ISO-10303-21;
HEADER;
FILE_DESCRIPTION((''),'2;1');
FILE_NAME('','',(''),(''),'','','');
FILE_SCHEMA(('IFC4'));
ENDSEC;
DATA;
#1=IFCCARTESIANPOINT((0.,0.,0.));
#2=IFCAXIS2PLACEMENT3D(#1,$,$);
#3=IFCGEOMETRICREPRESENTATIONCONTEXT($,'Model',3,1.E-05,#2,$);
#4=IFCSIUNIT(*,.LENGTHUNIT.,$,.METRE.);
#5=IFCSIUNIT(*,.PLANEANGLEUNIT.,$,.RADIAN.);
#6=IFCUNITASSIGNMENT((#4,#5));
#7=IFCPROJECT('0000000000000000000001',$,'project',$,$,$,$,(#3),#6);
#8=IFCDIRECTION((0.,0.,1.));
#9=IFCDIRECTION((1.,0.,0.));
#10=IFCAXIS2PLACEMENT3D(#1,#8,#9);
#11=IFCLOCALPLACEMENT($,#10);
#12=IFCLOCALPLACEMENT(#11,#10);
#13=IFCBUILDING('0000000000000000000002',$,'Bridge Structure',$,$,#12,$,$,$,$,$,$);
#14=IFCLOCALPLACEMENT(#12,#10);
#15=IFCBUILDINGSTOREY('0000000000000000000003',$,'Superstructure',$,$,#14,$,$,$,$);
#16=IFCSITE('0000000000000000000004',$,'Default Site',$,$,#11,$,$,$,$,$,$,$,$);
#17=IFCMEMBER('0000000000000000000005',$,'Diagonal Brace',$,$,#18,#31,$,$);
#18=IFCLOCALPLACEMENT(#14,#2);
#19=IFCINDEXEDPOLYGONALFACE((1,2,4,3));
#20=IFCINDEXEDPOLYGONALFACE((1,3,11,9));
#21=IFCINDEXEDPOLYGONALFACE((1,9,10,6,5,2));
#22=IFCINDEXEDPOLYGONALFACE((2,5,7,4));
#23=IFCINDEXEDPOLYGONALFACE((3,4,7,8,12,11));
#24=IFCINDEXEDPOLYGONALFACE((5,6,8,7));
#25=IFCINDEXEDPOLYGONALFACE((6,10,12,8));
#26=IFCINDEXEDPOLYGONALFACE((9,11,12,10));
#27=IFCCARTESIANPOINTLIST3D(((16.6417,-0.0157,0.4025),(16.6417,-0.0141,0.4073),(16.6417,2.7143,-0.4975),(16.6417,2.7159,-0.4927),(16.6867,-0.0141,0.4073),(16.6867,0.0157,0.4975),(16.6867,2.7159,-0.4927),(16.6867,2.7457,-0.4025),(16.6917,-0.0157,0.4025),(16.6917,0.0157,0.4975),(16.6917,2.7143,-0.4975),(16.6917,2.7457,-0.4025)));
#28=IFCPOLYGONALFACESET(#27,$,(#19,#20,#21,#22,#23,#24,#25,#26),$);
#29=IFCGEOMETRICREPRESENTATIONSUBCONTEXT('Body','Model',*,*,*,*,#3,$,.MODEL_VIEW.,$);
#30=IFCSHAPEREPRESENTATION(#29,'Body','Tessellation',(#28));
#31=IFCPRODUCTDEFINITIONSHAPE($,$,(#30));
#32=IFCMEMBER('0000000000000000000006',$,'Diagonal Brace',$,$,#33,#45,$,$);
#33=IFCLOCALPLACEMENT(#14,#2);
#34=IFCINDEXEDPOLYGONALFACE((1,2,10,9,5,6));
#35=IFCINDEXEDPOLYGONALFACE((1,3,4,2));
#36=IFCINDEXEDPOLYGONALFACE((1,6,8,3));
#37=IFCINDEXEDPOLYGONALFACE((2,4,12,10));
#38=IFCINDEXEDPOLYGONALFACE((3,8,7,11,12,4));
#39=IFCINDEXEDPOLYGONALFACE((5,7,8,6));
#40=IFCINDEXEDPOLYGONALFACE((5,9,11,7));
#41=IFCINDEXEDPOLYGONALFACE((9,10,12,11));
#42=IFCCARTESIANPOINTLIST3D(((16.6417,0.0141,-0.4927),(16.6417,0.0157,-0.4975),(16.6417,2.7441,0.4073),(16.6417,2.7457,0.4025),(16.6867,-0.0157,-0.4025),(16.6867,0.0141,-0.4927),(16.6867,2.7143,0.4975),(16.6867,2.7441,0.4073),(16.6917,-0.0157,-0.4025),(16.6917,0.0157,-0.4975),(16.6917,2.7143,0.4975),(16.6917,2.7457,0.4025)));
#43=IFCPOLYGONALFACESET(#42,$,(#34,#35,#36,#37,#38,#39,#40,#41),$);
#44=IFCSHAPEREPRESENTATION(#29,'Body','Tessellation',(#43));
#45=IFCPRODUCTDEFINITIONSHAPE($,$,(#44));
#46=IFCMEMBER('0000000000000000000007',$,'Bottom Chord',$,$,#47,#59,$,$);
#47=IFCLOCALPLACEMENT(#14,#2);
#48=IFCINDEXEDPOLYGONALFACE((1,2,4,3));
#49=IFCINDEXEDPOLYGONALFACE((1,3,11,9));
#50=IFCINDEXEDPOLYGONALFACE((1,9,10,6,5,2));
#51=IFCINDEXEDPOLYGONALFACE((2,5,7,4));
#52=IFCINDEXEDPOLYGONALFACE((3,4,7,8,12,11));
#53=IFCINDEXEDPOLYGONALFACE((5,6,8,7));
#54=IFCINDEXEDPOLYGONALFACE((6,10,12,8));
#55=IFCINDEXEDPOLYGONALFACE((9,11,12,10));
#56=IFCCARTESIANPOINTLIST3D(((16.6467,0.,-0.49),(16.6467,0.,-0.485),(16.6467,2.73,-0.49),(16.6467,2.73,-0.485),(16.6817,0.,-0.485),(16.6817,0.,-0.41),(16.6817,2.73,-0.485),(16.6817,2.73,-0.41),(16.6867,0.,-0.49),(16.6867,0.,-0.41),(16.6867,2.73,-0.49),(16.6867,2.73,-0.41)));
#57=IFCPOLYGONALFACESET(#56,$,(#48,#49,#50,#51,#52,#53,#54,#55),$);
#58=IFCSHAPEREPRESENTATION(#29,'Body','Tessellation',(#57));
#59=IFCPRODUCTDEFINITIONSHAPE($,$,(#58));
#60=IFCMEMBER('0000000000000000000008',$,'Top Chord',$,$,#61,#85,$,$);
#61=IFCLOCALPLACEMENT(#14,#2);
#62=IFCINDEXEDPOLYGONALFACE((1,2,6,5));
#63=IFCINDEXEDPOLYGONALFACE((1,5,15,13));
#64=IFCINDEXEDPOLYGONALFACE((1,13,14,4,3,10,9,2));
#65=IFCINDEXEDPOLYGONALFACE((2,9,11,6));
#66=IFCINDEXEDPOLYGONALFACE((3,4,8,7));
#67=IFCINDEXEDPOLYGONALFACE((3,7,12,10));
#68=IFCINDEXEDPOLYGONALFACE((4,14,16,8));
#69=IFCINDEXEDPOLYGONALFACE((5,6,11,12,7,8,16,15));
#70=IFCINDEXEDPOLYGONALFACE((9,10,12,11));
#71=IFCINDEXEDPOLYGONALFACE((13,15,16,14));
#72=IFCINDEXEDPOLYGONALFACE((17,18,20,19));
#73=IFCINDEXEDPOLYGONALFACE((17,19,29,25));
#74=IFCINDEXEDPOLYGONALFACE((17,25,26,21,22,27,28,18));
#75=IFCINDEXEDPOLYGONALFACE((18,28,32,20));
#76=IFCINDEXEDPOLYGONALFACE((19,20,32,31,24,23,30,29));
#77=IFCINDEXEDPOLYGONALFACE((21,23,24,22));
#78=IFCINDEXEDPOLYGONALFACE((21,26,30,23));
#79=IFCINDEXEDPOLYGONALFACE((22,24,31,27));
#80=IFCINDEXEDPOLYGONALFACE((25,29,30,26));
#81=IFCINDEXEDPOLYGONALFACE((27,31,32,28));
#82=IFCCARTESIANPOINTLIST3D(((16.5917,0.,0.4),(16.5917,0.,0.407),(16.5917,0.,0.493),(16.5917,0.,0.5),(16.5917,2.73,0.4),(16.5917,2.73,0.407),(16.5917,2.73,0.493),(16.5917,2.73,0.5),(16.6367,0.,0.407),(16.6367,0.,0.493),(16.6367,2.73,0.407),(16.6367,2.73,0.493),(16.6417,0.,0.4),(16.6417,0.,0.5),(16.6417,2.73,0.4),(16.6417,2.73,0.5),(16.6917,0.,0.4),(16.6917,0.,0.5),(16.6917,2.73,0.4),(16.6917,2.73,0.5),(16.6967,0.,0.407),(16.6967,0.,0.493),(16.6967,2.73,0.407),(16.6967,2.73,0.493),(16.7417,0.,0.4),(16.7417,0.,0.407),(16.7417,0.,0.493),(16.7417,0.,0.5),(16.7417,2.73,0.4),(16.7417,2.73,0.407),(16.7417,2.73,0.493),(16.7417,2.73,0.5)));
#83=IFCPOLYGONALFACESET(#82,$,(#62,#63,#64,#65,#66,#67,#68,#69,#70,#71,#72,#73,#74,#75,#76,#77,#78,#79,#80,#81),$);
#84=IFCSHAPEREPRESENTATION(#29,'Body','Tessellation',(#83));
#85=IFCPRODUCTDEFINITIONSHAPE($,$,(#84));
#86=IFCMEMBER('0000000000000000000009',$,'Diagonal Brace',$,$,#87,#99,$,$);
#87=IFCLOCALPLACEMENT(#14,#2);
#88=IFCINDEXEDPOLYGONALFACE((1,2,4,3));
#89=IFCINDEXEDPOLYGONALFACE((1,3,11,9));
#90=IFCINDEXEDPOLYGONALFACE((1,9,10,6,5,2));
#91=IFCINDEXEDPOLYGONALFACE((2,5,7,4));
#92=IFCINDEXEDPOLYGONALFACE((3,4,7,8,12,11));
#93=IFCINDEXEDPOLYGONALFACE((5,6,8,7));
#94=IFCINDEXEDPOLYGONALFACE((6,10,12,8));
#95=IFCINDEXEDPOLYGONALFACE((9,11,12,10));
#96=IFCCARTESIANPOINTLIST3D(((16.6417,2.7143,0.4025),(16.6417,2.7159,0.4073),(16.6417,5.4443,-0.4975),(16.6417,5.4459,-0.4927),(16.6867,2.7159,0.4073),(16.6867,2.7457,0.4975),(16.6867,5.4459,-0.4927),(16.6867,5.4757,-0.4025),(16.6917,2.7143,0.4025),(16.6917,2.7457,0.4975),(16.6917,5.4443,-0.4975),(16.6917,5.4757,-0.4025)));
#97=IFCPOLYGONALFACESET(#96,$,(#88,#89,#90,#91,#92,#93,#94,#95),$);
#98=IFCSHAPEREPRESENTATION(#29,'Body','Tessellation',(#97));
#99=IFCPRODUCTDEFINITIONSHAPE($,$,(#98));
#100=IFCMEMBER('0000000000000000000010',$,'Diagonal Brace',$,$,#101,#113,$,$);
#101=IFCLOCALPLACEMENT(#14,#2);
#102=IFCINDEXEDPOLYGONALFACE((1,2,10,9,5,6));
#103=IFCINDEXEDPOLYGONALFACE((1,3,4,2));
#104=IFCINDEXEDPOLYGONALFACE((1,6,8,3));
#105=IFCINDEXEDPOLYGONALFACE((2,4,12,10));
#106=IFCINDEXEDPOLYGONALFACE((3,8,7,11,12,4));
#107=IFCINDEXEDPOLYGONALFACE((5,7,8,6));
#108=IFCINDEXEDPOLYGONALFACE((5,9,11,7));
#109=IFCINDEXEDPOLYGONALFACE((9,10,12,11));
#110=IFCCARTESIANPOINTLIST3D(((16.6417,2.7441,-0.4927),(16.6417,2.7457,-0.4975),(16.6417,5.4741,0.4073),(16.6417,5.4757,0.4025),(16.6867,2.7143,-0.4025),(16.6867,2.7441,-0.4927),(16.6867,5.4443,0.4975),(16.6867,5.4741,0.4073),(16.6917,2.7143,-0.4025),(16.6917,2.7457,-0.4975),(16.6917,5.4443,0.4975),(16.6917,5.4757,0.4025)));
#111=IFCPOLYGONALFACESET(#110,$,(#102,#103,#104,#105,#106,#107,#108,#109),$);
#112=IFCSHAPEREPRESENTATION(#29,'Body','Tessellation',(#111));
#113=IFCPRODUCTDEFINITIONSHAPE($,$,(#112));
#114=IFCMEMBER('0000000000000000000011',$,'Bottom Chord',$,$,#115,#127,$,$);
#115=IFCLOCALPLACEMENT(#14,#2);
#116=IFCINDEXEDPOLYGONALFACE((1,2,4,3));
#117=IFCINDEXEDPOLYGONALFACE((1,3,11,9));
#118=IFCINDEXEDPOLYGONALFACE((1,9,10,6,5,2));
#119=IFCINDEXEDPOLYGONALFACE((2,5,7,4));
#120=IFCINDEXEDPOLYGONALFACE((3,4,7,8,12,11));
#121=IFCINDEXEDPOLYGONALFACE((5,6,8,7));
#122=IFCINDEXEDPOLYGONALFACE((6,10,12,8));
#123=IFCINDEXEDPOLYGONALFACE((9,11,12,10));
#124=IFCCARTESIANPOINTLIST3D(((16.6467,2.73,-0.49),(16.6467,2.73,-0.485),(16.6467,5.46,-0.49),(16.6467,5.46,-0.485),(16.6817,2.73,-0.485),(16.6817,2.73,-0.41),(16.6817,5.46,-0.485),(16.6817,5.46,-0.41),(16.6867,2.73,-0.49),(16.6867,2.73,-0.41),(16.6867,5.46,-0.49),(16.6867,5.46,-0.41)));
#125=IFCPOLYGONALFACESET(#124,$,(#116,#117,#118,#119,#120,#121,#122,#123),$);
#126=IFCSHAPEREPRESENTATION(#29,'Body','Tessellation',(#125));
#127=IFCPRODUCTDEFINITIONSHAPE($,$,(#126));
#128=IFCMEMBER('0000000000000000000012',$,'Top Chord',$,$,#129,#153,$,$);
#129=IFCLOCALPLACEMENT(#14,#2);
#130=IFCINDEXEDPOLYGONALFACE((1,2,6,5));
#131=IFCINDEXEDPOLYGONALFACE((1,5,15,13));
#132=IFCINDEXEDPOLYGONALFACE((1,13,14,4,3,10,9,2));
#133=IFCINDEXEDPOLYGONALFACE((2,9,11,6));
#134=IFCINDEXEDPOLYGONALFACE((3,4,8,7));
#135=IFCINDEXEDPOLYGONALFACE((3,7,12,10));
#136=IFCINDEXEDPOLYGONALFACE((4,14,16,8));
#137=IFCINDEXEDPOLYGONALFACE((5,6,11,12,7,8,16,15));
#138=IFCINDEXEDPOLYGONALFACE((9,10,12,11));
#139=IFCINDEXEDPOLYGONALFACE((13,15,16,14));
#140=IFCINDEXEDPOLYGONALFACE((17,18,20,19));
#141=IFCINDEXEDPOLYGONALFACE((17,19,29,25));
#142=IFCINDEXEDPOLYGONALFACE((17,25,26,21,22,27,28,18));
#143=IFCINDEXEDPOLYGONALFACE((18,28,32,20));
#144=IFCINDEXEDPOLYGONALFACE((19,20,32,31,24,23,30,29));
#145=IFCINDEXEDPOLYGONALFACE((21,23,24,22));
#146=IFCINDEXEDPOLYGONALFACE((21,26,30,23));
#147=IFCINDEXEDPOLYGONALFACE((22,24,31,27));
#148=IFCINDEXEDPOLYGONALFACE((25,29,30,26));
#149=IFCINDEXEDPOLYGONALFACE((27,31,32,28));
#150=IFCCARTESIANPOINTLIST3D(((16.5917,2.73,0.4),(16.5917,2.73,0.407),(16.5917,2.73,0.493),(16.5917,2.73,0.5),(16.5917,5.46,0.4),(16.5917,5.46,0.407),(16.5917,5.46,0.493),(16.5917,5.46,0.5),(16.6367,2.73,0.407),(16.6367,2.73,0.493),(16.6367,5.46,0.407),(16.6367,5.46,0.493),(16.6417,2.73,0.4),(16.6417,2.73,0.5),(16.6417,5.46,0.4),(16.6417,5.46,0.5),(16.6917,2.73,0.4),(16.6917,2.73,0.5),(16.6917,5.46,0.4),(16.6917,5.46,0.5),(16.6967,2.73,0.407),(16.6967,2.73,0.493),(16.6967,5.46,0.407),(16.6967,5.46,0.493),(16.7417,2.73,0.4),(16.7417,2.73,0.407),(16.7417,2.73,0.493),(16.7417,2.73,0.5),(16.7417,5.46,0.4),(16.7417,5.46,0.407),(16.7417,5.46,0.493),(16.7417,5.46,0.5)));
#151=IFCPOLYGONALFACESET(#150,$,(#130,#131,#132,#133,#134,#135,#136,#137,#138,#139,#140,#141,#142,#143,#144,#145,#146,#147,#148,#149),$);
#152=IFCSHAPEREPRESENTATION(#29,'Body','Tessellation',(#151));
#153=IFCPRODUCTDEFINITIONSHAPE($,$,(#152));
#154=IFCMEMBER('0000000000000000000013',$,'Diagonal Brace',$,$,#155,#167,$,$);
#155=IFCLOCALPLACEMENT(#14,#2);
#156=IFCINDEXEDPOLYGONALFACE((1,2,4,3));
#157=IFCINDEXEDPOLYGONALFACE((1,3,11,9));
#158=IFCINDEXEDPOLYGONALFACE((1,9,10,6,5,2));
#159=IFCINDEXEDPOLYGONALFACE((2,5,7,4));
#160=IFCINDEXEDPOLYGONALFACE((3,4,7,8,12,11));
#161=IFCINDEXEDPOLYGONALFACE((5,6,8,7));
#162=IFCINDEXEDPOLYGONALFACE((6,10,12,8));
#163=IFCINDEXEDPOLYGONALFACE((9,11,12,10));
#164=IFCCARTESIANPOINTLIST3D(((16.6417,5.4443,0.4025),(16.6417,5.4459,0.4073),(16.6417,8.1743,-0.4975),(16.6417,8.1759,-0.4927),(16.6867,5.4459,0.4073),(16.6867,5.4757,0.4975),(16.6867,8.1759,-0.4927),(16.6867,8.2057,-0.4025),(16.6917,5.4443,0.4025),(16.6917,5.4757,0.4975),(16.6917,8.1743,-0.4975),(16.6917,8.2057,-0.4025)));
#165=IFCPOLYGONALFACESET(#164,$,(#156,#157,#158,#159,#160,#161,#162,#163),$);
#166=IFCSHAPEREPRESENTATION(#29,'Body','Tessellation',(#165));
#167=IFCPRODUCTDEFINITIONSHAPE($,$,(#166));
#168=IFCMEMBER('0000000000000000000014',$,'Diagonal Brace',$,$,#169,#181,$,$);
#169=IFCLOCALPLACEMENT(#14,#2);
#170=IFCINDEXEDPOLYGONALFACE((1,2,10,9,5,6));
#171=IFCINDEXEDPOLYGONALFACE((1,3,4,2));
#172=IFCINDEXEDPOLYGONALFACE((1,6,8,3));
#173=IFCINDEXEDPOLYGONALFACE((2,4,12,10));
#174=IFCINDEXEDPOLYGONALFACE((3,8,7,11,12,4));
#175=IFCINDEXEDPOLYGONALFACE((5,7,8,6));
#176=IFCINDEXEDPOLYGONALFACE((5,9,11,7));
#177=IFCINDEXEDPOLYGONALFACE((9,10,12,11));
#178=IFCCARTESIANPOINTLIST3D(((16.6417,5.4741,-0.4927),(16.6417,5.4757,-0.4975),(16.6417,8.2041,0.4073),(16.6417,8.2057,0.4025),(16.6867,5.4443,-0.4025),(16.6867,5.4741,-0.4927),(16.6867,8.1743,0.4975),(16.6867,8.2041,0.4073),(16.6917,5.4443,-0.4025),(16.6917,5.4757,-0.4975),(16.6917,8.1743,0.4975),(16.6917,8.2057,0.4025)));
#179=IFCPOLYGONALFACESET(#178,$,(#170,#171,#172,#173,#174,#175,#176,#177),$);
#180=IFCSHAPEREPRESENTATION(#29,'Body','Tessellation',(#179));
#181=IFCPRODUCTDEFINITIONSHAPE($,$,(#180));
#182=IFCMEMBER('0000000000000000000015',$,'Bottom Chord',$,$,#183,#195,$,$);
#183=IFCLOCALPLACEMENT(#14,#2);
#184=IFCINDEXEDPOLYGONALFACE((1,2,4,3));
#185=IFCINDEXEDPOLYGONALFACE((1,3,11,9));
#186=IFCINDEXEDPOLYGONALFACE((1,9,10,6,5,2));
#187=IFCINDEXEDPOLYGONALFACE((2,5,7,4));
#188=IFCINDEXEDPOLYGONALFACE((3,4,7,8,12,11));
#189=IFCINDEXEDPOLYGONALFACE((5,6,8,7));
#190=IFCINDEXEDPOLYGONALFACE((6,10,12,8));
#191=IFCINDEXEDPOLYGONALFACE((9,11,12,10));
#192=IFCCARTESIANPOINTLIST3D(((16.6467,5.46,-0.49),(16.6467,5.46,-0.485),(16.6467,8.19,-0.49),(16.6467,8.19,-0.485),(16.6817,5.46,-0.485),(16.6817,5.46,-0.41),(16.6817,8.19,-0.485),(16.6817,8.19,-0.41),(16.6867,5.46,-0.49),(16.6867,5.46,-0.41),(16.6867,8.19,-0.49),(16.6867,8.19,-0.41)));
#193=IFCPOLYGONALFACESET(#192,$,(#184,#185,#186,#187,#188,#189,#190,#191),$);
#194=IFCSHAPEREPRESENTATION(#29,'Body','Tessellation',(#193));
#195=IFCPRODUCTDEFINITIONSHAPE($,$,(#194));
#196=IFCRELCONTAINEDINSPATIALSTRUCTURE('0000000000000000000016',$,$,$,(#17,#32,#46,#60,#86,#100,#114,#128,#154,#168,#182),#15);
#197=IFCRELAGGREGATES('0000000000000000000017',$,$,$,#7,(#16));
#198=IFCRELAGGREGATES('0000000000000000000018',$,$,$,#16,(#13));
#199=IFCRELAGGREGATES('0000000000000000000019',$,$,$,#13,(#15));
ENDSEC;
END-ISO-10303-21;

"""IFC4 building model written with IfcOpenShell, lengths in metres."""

from ifc_helpers import new_model, si_unit, frame, origin, origin_with_axes, origin_2d_with_axis, place, context, subcontext, project, spatial, polyline, l_section, outline, composite_profile, extrude, element, save


model = new_model("IFC4")

# Units and contexts
model_context = context("Model", 3, precision=1e-05, world=origin())
body_context = subcontext(model_context, "Body", "Model", "MODEL_VIEW")
ifc_project = project(units=[si_unit("LENGTHUNIT", "METRE"), si_unit("PLANEANGLEUNIT", "RADIAN")], contexts=[model_context])

# Site, building, storey
site_placement = place(None, origin_with_axes())
site = spatial("IfcSite", under=ifc_project, at=site_placement, Name="Default Site")
building_placement = place(site_placement, origin_with_axes())
building = spatial("IfcBuilding", under=site, at=building_placement, Name="Bridge Structure")
storey_placement = place(building_placement, origin_with_axes())
storey = spatial("IfcBuildingStorey", under=building, at=storey_placement, Name="Superstructure")

# Members
for number, where, z_axis, x_axis, name in (
    (1, (16.6667, 0.0, 0.45), (0.0, 0.949722, -0.313095), (-1.0, 0.0, 0.0), "Diagonal Brace"),
    (2, (16.6667, 0.0, -0.45), (0.0, 0.949722, 0.313095), (-1.0, 0.0, 0.0), "Diagonal Brace"),
):
    element("IfcMember", number, at=place(storey_placement, frame(where, z_axis=z_axis, x_axis=x_axis)), inside=storey, Name=name, context=body_context, shape_type="SweptSolid", body=[
        extrude(l_section(Depth=0.1, Width=0.05, Thickness=0.005, at=origin_2d_with_axis()), origin_with_axes(), (0.0, 0.0, 1.0), 2.8745),
    ])
member_1_placement = place(storey_placement, frame((16.6667, 0.0, -0.45), z_axis=(0.0, 1.0, 0.0), x_axis=(-1.0, 0.0, 0.0)))
element("IfcMember", 3, at=member_1_placement, inside=storey, Name="Bottom Chord", context=body_context, shape_type="SweptSolid", body=[
    extrude(l_section(Depth=0.08, Width=0.04, Thickness=0.005, at=origin_2d_with_axis()), origin_with_axes(), (0.0, 0.0, 1.0), 2.73),
])
member_2_placement = place(storey_placement, frame((16.6667, 0.0, 0.45), z_axis=(0.0, 1.0, 0.0), x_axis=(-1.0, 0.0, 0.0)))
element("IfcMember", 4, at=member_2_placement, inside=storey, Name="Top Chord", context=body_context, shape_type="SweptSolid", body=[
    extrude(composite_profile([outline(polyline([(-0.025, -0.05), (-0.025, 0.05), (-0.075, 0.05), (-0.075, 0.043), (-0.03, 0.043), (-0.03, -0.043), (-0.075, -0.043), (-0.075, -0.05), (-0.025, -0.05)])), outline(polyline([(0.025, -0.05), (0.075, -0.05), (0.075, -0.043), (0.03, -0.043), (0.03, 0.043), (0.075, 0.043), (0.075, 0.05), (0.025, 0.05), (0.025, -0.05)]))]), origin_with_axes(), (0.0, 0.0, 1.0), 2.73),
])
for number, where, z_axis, x_axis, name in (
    (5, (16.6667, 2.73, 0.45), (0.0, 0.949722, -0.313095), (-1.0, 0.0, 0.0), "Diagonal Brace"),
    (6, (16.6667, 2.73, -0.45), (0.0, 0.949722, 0.313095), (-1.0, 0.0, 0.0), "Diagonal Brace"),
):
    element("IfcMember", number, at=place(storey_placement, frame(where, z_axis=z_axis, x_axis=x_axis)), inside=storey, Name=name, context=body_context, shape_type="SweptSolid", body=[
        extrude(l_section(Depth=0.1, Width=0.05, Thickness=0.005, at=origin_2d_with_axis()), origin_with_axes(), (0.0, 0.0, 1.0), 2.8745),
    ])
member_3_placement = place(storey_placement, frame((16.6667, 2.73, -0.45), z_axis=(0.0, 1.0, 0.0), x_axis=(-1.0, 0.0, 0.0)))
element("IfcMember", 7, at=member_3_placement, inside=storey, Name="Bottom Chord", context=body_context, shape_type="SweptSolid", body=[
    extrude(l_section(Depth=0.08, Width=0.04, Thickness=0.005, at=origin_2d_with_axis()), origin_with_axes(), (0.0, 0.0, 1.0), 2.73),
])
member_4_placement = place(storey_placement, frame((16.6667, 2.73, 0.45), z_axis=(0.0, 1.0, 0.0), x_axis=(-1.0, 0.0, 0.0)))
element("IfcMember", 8, at=member_4_placement, inside=storey, Name="Top Chord", context=body_context, shape_type="SweptSolid", body=[
    extrude(composite_profile([outline(polyline([(-0.025, -0.05), (-0.025, 0.05), (-0.075, 0.05), (-0.075, 0.043), (-0.03, 0.043), (-0.03, -0.043), (-0.075, -0.043), (-0.075, -0.05), (-0.025, -0.05)])), outline(polyline([(0.025, -0.05), (0.075, -0.05), (0.075, -0.043), (0.03, -0.043), (0.03, 0.043), (0.075, 0.043), (0.075, 0.05), (0.025, 0.05), (0.025, -0.05)]))]), origin_with_axes(), (0.0, 0.0, 1.0), 2.73),
])
for number, where, z_axis, x_axis, name in (
    (9, (16.6667, 5.46, 0.45), (0.0, 0.949722, -0.313095), (-1.0, 0.0, 0.0), "Diagonal Brace"),
    (10, (16.6667, 5.46, -0.45), (0.0, 0.949722, 0.313095), (-1.0, 0.0, 0.0), "Diagonal Brace"),
):
    element("IfcMember", number, at=place(storey_placement, frame(where, z_axis=z_axis, x_axis=x_axis)), inside=storey, Name=name, context=body_context, shape_type="SweptSolid", body=[
        extrude(l_section(Depth=0.1, Width=0.05, Thickness=0.005, at=origin_2d_with_axis()), origin_with_axes(), (0.0, 0.0, 1.0), 2.8745),
    ])
member_5_placement = place(storey_placement, frame((16.6667, 5.46, -0.45), z_axis=(0.0, 1.0, 0.0), x_axis=(-1.0, 0.0, 0.0)))
element("IfcMember", 11, at=member_5_placement, inside=storey, Name="Bottom Chord", context=body_context, shape_type="SweptSolid", body=[
    extrude(l_section(Depth=0.08, Width=0.04, Thickness=0.005, at=origin_2d_with_axis()), origin_with_axes(), (0.0, 0.0, 1.0), 2.73),
])

save(model, "model.ifc")
